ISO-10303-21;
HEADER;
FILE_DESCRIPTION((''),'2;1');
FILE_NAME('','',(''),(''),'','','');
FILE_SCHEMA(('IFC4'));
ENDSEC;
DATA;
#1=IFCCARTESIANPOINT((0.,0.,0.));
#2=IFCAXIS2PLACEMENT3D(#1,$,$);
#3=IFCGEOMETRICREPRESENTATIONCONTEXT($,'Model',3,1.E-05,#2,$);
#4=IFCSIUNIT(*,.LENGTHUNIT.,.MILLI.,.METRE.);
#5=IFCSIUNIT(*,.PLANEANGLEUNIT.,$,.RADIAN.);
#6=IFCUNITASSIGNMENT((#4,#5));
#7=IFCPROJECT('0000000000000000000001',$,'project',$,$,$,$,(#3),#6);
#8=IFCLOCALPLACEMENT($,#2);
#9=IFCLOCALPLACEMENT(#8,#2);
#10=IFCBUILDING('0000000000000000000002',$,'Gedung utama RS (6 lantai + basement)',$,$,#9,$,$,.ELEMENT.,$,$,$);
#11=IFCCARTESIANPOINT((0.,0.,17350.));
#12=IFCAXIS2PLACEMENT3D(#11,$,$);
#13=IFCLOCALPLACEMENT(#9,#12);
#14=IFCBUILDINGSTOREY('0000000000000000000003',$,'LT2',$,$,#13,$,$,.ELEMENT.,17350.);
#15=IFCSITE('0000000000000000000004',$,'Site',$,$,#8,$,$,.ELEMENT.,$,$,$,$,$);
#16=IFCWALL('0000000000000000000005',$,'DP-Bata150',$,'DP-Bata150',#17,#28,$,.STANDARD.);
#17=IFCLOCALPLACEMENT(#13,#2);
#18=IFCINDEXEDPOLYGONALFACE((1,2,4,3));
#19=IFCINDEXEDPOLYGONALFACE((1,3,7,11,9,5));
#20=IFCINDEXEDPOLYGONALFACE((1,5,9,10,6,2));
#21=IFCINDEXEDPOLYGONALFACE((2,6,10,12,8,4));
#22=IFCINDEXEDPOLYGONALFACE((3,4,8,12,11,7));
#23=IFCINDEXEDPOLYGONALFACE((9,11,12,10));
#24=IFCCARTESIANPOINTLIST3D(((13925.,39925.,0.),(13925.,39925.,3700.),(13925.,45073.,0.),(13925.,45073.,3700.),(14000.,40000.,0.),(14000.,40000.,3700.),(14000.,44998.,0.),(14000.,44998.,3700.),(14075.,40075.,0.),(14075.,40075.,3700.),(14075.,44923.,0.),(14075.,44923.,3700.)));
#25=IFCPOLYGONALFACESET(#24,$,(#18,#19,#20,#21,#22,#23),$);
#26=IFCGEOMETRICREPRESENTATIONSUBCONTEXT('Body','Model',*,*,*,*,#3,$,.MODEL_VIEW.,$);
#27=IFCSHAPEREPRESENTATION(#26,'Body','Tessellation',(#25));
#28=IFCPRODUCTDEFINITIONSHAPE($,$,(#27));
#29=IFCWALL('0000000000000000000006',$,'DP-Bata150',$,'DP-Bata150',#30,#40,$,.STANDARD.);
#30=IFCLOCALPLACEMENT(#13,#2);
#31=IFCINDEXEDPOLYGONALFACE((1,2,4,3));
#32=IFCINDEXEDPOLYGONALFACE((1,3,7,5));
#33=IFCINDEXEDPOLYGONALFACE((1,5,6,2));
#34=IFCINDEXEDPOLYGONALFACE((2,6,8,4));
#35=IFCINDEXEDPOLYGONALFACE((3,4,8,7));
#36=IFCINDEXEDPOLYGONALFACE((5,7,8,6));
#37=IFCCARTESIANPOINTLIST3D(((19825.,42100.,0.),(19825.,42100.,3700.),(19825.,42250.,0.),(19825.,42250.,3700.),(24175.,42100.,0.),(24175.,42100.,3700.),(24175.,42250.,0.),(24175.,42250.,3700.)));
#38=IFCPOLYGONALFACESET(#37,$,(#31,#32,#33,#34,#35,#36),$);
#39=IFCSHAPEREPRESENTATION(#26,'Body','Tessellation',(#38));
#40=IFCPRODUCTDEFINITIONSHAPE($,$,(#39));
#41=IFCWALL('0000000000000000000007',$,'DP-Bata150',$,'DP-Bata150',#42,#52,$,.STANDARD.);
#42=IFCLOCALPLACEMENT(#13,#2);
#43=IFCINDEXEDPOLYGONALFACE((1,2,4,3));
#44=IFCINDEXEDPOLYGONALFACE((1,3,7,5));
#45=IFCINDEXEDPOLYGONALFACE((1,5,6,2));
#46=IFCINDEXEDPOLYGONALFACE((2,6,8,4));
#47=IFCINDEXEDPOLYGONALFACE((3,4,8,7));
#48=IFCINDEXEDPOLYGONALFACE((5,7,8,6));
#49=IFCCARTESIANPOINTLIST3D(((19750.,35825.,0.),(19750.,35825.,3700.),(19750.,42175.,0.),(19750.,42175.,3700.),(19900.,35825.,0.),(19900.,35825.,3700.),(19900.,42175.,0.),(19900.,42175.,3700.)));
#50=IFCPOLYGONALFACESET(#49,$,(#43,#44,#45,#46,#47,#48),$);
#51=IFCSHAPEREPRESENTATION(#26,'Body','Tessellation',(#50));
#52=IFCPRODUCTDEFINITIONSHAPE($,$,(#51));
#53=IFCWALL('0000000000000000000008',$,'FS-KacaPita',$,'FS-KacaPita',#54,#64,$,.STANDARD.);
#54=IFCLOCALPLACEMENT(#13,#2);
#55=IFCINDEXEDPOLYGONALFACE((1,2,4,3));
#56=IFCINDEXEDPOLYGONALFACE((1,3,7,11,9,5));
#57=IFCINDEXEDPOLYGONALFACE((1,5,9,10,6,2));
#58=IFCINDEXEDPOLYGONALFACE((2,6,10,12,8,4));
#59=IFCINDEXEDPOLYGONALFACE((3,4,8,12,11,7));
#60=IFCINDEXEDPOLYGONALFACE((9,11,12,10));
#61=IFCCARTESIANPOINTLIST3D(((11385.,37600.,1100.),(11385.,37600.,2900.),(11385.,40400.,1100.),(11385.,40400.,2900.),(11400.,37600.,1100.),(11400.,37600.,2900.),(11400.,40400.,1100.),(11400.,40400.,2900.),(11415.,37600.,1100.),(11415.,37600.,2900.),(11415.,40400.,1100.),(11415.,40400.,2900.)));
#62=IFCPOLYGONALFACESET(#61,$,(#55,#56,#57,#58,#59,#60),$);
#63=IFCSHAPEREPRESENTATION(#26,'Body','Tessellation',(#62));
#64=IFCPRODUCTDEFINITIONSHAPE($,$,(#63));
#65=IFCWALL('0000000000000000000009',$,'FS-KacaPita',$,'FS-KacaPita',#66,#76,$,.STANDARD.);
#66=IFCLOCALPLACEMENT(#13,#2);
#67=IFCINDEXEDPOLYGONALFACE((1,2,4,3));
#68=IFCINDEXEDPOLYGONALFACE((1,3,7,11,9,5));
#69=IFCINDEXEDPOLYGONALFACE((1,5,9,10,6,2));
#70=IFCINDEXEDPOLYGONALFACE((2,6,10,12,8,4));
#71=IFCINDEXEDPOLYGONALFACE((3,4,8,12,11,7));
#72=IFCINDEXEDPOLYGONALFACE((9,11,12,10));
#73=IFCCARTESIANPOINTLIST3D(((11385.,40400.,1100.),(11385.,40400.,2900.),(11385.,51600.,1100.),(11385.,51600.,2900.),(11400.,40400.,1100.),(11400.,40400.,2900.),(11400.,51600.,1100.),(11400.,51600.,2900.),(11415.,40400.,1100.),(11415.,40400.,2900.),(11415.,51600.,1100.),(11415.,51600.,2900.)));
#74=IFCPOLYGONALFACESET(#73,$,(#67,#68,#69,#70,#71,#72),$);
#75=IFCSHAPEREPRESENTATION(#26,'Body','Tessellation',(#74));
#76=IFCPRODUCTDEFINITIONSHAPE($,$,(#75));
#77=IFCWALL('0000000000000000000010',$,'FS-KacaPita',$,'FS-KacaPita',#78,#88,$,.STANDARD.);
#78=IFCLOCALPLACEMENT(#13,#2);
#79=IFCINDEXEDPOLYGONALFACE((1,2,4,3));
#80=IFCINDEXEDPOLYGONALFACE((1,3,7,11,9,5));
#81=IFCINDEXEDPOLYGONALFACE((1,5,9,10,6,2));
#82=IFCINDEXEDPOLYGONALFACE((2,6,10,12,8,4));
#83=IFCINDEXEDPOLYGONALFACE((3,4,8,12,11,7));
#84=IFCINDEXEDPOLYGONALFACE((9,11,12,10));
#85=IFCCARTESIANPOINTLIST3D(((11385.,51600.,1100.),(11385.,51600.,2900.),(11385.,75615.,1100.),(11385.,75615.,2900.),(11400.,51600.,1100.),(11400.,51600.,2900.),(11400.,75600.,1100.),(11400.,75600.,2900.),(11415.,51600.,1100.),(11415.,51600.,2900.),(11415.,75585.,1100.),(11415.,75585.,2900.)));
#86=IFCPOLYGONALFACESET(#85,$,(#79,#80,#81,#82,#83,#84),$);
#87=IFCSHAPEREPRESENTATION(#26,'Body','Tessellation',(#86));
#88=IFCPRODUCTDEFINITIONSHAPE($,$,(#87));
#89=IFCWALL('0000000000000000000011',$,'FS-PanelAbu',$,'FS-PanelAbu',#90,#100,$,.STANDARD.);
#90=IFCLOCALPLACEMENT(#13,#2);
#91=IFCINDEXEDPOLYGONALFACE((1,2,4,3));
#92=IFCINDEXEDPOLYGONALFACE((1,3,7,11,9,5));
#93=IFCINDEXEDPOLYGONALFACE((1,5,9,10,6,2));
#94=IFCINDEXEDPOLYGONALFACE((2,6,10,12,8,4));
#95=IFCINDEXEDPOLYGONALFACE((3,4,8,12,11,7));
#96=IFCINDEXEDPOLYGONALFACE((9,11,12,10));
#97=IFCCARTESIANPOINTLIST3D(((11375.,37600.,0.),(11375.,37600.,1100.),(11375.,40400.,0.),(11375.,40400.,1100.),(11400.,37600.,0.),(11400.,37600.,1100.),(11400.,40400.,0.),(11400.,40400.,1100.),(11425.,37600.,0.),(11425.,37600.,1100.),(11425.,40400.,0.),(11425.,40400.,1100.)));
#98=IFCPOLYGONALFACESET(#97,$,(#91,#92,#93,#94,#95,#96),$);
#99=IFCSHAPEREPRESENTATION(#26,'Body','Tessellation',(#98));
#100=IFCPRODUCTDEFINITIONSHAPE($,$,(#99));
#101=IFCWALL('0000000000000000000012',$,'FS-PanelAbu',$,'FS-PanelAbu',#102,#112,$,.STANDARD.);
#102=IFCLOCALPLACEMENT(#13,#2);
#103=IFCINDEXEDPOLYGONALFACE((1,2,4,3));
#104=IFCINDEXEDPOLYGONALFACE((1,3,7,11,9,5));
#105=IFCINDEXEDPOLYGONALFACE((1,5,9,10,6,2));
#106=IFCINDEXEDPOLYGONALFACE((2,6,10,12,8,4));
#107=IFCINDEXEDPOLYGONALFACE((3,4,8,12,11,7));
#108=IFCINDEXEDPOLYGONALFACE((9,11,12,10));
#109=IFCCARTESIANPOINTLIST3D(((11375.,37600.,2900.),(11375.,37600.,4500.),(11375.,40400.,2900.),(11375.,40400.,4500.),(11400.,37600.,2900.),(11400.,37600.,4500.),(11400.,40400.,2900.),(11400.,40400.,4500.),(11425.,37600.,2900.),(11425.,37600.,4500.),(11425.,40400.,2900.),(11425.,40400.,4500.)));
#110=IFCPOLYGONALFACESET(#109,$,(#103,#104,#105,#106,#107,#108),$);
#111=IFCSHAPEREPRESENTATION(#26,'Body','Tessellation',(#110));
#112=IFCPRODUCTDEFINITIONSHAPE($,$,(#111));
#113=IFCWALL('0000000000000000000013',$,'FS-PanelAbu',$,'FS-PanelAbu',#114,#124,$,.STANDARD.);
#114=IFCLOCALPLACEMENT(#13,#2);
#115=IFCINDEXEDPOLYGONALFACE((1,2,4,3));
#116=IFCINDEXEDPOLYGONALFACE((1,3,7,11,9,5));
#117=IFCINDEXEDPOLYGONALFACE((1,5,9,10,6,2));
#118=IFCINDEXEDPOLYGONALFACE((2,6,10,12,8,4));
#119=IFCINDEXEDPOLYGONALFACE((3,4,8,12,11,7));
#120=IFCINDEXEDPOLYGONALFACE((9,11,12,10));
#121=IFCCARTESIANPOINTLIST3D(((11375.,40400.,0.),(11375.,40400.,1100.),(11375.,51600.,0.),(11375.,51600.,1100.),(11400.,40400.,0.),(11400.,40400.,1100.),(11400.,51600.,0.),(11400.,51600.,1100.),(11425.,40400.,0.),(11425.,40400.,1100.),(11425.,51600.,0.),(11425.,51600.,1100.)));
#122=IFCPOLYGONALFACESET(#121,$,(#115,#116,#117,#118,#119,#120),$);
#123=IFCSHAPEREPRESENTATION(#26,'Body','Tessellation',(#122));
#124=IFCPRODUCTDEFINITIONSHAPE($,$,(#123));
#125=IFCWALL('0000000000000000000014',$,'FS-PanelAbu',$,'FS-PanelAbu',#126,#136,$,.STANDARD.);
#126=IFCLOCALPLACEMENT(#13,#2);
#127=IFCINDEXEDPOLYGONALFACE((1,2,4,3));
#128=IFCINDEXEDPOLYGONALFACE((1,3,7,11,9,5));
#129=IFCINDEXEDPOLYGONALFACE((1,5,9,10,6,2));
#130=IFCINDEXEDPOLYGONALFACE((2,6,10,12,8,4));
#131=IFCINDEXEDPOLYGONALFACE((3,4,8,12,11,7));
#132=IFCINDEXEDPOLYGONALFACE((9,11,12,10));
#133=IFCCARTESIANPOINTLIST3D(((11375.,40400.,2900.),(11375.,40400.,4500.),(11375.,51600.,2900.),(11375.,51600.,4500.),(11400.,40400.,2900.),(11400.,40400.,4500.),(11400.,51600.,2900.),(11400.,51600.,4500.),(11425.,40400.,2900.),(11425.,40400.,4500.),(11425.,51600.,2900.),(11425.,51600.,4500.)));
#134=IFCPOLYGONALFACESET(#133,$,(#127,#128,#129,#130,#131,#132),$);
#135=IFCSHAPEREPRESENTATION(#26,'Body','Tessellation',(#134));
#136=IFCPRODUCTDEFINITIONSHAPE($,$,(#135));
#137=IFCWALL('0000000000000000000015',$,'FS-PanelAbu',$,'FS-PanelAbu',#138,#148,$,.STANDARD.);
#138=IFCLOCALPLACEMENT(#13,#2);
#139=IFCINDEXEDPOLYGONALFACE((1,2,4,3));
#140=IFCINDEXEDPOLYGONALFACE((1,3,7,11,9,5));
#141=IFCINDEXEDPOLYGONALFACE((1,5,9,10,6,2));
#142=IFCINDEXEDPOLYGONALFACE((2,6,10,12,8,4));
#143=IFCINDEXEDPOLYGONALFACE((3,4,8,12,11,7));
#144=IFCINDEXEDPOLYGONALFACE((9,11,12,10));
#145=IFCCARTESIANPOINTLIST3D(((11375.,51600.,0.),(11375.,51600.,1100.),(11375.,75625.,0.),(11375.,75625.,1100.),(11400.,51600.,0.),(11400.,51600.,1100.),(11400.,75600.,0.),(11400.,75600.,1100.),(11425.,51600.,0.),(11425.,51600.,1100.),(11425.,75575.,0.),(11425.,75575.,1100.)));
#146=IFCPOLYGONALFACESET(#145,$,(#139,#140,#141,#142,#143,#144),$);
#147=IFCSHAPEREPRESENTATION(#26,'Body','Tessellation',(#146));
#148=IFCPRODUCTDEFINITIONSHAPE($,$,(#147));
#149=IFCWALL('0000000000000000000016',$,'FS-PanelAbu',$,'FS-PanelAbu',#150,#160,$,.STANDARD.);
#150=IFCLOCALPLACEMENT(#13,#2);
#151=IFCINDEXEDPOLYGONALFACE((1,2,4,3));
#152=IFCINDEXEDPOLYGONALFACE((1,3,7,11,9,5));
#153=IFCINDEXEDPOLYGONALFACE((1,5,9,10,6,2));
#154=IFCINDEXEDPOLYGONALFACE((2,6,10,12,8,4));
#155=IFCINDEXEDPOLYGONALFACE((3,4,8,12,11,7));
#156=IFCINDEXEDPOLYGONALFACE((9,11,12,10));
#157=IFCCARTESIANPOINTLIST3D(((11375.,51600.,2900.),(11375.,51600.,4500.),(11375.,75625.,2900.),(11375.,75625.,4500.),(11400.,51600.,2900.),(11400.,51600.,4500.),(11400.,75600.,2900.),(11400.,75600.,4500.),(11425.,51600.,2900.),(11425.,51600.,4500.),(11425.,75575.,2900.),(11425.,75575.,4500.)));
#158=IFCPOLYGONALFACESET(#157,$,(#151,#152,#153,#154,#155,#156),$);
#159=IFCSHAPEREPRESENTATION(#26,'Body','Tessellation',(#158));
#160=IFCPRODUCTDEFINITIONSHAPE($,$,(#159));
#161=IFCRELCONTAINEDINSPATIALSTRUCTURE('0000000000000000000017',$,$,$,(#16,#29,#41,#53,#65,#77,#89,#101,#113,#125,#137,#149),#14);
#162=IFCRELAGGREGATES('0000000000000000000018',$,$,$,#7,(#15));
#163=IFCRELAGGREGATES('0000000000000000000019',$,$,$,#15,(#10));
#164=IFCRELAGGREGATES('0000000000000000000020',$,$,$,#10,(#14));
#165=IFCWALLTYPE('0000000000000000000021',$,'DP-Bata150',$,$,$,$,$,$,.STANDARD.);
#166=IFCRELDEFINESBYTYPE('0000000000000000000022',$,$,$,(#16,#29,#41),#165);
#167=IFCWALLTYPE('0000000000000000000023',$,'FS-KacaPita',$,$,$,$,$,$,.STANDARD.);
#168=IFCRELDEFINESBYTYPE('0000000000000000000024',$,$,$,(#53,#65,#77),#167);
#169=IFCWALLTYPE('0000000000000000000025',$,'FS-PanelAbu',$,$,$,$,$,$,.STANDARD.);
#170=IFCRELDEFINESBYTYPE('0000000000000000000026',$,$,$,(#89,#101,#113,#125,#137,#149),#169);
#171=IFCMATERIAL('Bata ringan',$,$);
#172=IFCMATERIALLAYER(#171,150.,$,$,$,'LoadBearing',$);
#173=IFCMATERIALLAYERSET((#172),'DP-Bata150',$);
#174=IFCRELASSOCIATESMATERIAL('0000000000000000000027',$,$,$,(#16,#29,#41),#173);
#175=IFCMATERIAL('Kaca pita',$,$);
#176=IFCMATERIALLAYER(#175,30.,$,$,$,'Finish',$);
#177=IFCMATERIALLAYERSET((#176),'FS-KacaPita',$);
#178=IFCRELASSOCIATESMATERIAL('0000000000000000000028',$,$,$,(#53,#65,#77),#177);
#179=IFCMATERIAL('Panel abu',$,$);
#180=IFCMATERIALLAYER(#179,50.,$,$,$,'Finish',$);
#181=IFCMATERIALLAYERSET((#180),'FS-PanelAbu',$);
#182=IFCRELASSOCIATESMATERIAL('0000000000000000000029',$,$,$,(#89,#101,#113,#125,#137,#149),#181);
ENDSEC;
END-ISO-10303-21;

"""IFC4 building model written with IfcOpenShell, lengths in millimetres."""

from ifc_helpers import new_model, si_unit, frame, origin, place, context, subcontext, project, spatial, polyline, outline, extrude, material, layer, layer_set, layer_usage, type_object, element, save


model = new_model("IFC4")

# Units and contexts
model_context = context("Model", 3, precision=1e-05, world=origin())
body_context = subcontext(model_context, "Body", "Model", "MODEL_VIEW")
ifc_project = project(units=[si_unit("LENGTHUNIT", "METRE", prefix="MILLI"), si_unit("PLANEANGLEUNIT", "RADIAN")], contexts=[model_context])

# Site, building, storey
site_placement = place(None, origin())
site = spatial("IfcSite", under=ifc_project, at=site_placement, Name="Site", CompositionType="ELEMENT")
building_placement = place(site_placement, origin())
building = spatial("IfcBuilding", under=site, at=building_placement, Name="Gedung utama RS (6 lantai + basement)", CompositionType="ELEMENT")
storey_placement = place(building_placement, frame((0.0, 0.0, 17350.0)))
storey = spatial("IfcBuildingStorey", under=building, at=storey_placement, Name="LT2", CompositionType="ELEMENT", Elevation=17350.0)

# Shared definitions
ifc_material_1 = material(Name="Bata ringan")

# Shared definitions
ifc_layer_1 = layer(ifc_material_1, 150.0, Category="LoadBearing")
ifc_layer_set_1 = layer_set([ifc_layer_1], Name="DP-Bata150")
ifc_layer_usage_1 = layer_usage(ifc_layer_set_1, "AXIS2", "NEGATIVE", 75.0)
wall_type_1 = type_object("IfcWallType", Name="DP-Bata150", PredefinedType="STANDARD")

# Walls
wall_1_placement = place(storey_placement, frame((14000.0, 44998.0, 0.0), z_axis=(0.0, 0.0, 1.0), x_axis=(0.0, -1.0, 0.0)))
element("IfcWall", 1, at=wall_1_placement, inside=storey, type_object=wall_type_1, material=ifc_layer_usage_1, Name="DP-Bata150", ObjectType="DP-Bata150", PredefinedType="STANDARD", context=body_context, shape_type="SweptSolid", body=[
    extrude(outline(polyline([(-75.0, -75.0), (0.0, 0.0), (75.0, 75.0), (4923.0, 75.0), (4998.0, 0.0), (5073.0, -75.0), (-75.0, -75.0)])), origin(), (0.0, 0.0, 1.0), 3700.0),
])
wall_2_placement = place(storey_placement, frame((24175.0, 42175.0, 0.0), z_axis=(0.0, 0.0, 1.0), x_axis=(-1.0, 0.0, 0.0)))
element("IfcWall", 2, at=wall_2_placement, inside=storey, type_object=wall_type_1, material=ifc_layer_usage_1, Name="DP-Bata150", ObjectType="DP-Bata150", PredefinedType="STANDARD", context=body_context, shape_type="SweptSolid", body=[
    extrude(outline(polyline([(0.0, -75.0), (0.0, 75.0), (4350.0, 75.0), (4350.0, -75.0), (0.0, -75.0)])), origin(), (0.0, 0.0, 1.0), 3700.0),
])
wall_3_placement = place(storey_placement, frame((19825.0, 42175.0, 0.0), z_axis=(0.0, 0.0, 1.0), x_axis=(0.0, -1.0, 0.0)))
element("IfcWall", 3, at=wall_3_placement, inside=storey, type_object=wall_type_1, material=ifc_layer_usage_1, Name="DP-Bata150", ObjectType="DP-Bata150", PredefinedType="STANDARD", context=body_context, shape_type="SweptSolid", body=[
    extrude(outline(polyline([(0.0, -75.0), (0.0, 75.0), (6350.0, 75.0), (6350.0, -75.0), (0.0, -75.0)])), origin(), (0.0, 0.0, 1.0), 3700.0),
])
ifc_material_2 = material(Name="Kaca pita")
ifc_layer_2 = layer(ifc_material_2, 30.0, Category="Finish")
ifc_layer_set_2 = layer_set([ifc_layer_2], Name="FS-KacaPita")
ifc_layer_usage_2 = layer_usage(ifc_layer_set_2, "AXIS2", "NEGATIVE", 15.0)
wall_type_2 = type_object("IfcWallType", Name="FS-KacaPita", PredefinedType="STANDARD")
wall_4_placement = place(storey_placement, frame((11400.0, 37600.0, 1100.0), z_axis=(0.0, 0.0, 1.0), x_axis=(0.0, 1.0, 0.0)))
element("IfcWall", 4, at=wall_4_placement, inside=storey, type_object=wall_type_2, material=ifc_layer_usage_2, Name="FS-KacaPita", ObjectType="FS-KacaPita", PredefinedType="STANDARD", context=body_context, shape_type="SweptSolid", body=[
    extrude(outline(polyline([(0.0, -15.0), (0.0, 0.0), (0.0, 15.0), (2800.0, 15.0), (2800.0, 0.0), (2800.0, -15.0), (0.0, -15.0)])), origin(), (0.0, 0.0, 1.0), 1800.0),
])
wall_5_placement = place(storey_placement, frame((11400.0, 40400.0, 1100.0), z_axis=(0.0, 0.0, 1.0), x_axis=(0.0, 1.0, 0.0)))
element("IfcWall", 5, at=wall_5_placement, inside=storey, type_object=wall_type_2, material=ifc_layer_usage_2, Name="FS-KacaPita", ObjectType="FS-KacaPita", PredefinedType="STANDARD", context=body_context, shape_type="SweptSolid", body=[
    extrude(outline(polyline([(0.0, -15.0), (0.0, 0.0), (0.0, 15.0), (11200.0, 15.0), (11200.0, 0.0), (11200.0, -15.0), (0.0, -15.0)])), origin(), (0.0, 0.0, 1.0), 1800.0),
])
wall_6_placement = place(storey_placement, frame((11400.0, 51600.0, 1100.0), z_axis=(0.0, 0.0, 1.0), x_axis=(0.0, 1.0, 0.0)))
element("IfcWall", 6, at=wall_6_placement, inside=storey, type_object=wall_type_2, material=ifc_layer_usage_2, Name="FS-KacaPita", ObjectType="FS-KacaPita", PredefinedType="STANDARD", context=body_context, shape_type="SweptSolid", body=[
    extrude(outline(polyline([(0.0, -15.0), (0.0, 0.0), (0.0, 15.0), (24015.0, 15.0), (24000.0, 0.0), (23985.0, -15.0), (0.0, -15.0)])), origin(), (0.0, 0.0, 1.0), 1800.0),
])
ifc_material_3 = material(Name="Panel abu")
ifc_layer_3 = layer(ifc_material_3, 50.0, Category="Finish")
ifc_layer_set_3 = layer_set([ifc_layer_3], Name="FS-PanelAbu")
ifc_layer_usage_3 = layer_usage(ifc_layer_set_3, "AXIS2", "NEGATIVE", 25.0)
wall_type_3 = type_object("IfcWallType", Name="FS-PanelAbu", PredefinedType="STANDARD")
wall_7_placement = place(storey_placement, frame((11400.0, 37600.0, 0.0), z_axis=(0.0, 0.0, 1.0), x_axis=(0.0, 1.0, 0.0)))
element("IfcWall", 7, at=wall_7_placement, inside=storey, type_object=wall_type_3, material=ifc_layer_usage_3, Name="FS-PanelAbu", ObjectType="FS-PanelAbu", PredefinedType="STANDARD", context=body_context, shape_type="SweptSolid", body=[
    extrude(outline(polyline([(0.0, -25.0), (0.0, 0.0), (0.0, 25.0), (2800.0, 25.0), (2800.0, 0.0), (2800.0, -25.0), (0.0, -25.0)])), origin(), (0.0, 0.0, 1.0), 1100.0),
])
wall_8_placement = place(storey_placement, frame((11400.0, 37600.0, 2900.0), z_axis=(0.0, 0.0, 1.0), x_axis=(0.0, 1.0, 0.0)))
element("IfcWall", 8, at=wall_8_placement, inside=storey, type_object=wall_type_3, material=ifc_layer_usage_3, Name="FS-PanelAbu", ObjectType="FS-PanelAbu", PredefinedType="STANDARD", context=body_context, shape_type="SweptSolid", body=[
    extrude(outline(polyline([(0.0, -25.0), (0.0, 0.0), (0.0, 25.0), (2800.0, 25.0), (2800.0, 0.0), (2800.0, -25.0), (0.0, -25.0)])), origin(), (0.0, 0.0, 1.0), 1600.0),
])
wall_9_placement = place(storey_placement, frame((11400.0, 40400.0, 0.0), z_axis=(0.0, 0.0, 1.0), x_axis=(0.0, 1.0, 0.0)))
element("IfcWall", 9, at=wall_9_placement, inside=storey, type_object=wall_type_3, material=ifc_layer_usage_3, Name="FS-PanelAbu", ObjectType="FS-PanelAbu", PredefinedType="STANDARD", context=body_context, shape_type="SweptSolid", body=[
    extrude(outline(polyline([(0.0, -25.0), (0.0, 0.0), (0.0, 25.0), (11200.0, 25.0), (11200.0, 0.0), (11200.0, -25.0), (0.0, -25.0)])), origin(), (0.0, 0.0, 1.0), 1100.0),
])
wall_10_placement = place(storey_placement, frame((11400.0, 40400.0, 2900.0), z_axis=(0.0, 0.0, 1.0), x_axis=(0.0, 1.0, 0.0)))
element("IfcWall", 10, at=wall_10_placement, inside=storey, type_object=wall_type_3, material=ifc_layer_usage_3, Name="FS-PanelAbu", ObjectType="FS-PanelAbu", PredefinedType="STANDARD", context=body_context, shape_type="SweptSolid", body=[
    extrude(outline(polyline([(0.0, -25.0), (0.0, 0.0), (0.0, 25.0), (11200.0, 25.0), (11200.0, 0.0), (11200.0, -25.0), (0.0, -25.0)])), origin(), (0.0, 0.0, 1.0), 1600.0),
])
wall_11_placement = place(storey_placement, frame((11400.0, 51600.0, 0.0), z_axis=(0.0, 0.0, 1.0), x_axis=(0.0, 1.0, 0.0)))
element("IfcWall", 11, at=wall_11_placement, inside=storey, type_object=wall_type_3, material=ifc_layer_usage_3, Name="FS-PanelAbu", ObjectType="FS-PanelAbu", PredefinedType="STANDARD", context=body_context, shape_type="SweptSolid", body=[
    extrude(outline(polyline([(0.0, -25.0), (0.0, 0.0), (0.0, 25.0), (24025.0, 25.0), (24000.0, 0.0), (23975.0, -25.0), (0.0, -25.0)])), origin(), (0.0, 0.0, 1.0), 1100.0),
])
wall_12_placement = place(storey_placement, frame((11400.0, 51600.0, 2900.0), z_axis=(0.0, 0.0, 1.0), x_axis=(0.0, 1.0, 0.0)))
element("IfcWall", 12, at=wall_12_placement, inside=storey, type_object=wall_type_3, material=ifc_layer_usage_3, Name="FS-PanelAbu", ObjectType="FS-PanelAbu", PredefinedType="STANDARD", context=body_context, shape_type="SweptSolid", body=[
    extrude(outline(polyline([(0.0, -25.0), (0.0, 0.0), (0.0, 25.0), (24025.0, 25.0), (24000.0, 0.0), (23975.0, -25.0), (0.0, -25.0)])), origin(), (0.0, 0.0, 1.0), 1600.0),
])

save(model, "model.ifc")
